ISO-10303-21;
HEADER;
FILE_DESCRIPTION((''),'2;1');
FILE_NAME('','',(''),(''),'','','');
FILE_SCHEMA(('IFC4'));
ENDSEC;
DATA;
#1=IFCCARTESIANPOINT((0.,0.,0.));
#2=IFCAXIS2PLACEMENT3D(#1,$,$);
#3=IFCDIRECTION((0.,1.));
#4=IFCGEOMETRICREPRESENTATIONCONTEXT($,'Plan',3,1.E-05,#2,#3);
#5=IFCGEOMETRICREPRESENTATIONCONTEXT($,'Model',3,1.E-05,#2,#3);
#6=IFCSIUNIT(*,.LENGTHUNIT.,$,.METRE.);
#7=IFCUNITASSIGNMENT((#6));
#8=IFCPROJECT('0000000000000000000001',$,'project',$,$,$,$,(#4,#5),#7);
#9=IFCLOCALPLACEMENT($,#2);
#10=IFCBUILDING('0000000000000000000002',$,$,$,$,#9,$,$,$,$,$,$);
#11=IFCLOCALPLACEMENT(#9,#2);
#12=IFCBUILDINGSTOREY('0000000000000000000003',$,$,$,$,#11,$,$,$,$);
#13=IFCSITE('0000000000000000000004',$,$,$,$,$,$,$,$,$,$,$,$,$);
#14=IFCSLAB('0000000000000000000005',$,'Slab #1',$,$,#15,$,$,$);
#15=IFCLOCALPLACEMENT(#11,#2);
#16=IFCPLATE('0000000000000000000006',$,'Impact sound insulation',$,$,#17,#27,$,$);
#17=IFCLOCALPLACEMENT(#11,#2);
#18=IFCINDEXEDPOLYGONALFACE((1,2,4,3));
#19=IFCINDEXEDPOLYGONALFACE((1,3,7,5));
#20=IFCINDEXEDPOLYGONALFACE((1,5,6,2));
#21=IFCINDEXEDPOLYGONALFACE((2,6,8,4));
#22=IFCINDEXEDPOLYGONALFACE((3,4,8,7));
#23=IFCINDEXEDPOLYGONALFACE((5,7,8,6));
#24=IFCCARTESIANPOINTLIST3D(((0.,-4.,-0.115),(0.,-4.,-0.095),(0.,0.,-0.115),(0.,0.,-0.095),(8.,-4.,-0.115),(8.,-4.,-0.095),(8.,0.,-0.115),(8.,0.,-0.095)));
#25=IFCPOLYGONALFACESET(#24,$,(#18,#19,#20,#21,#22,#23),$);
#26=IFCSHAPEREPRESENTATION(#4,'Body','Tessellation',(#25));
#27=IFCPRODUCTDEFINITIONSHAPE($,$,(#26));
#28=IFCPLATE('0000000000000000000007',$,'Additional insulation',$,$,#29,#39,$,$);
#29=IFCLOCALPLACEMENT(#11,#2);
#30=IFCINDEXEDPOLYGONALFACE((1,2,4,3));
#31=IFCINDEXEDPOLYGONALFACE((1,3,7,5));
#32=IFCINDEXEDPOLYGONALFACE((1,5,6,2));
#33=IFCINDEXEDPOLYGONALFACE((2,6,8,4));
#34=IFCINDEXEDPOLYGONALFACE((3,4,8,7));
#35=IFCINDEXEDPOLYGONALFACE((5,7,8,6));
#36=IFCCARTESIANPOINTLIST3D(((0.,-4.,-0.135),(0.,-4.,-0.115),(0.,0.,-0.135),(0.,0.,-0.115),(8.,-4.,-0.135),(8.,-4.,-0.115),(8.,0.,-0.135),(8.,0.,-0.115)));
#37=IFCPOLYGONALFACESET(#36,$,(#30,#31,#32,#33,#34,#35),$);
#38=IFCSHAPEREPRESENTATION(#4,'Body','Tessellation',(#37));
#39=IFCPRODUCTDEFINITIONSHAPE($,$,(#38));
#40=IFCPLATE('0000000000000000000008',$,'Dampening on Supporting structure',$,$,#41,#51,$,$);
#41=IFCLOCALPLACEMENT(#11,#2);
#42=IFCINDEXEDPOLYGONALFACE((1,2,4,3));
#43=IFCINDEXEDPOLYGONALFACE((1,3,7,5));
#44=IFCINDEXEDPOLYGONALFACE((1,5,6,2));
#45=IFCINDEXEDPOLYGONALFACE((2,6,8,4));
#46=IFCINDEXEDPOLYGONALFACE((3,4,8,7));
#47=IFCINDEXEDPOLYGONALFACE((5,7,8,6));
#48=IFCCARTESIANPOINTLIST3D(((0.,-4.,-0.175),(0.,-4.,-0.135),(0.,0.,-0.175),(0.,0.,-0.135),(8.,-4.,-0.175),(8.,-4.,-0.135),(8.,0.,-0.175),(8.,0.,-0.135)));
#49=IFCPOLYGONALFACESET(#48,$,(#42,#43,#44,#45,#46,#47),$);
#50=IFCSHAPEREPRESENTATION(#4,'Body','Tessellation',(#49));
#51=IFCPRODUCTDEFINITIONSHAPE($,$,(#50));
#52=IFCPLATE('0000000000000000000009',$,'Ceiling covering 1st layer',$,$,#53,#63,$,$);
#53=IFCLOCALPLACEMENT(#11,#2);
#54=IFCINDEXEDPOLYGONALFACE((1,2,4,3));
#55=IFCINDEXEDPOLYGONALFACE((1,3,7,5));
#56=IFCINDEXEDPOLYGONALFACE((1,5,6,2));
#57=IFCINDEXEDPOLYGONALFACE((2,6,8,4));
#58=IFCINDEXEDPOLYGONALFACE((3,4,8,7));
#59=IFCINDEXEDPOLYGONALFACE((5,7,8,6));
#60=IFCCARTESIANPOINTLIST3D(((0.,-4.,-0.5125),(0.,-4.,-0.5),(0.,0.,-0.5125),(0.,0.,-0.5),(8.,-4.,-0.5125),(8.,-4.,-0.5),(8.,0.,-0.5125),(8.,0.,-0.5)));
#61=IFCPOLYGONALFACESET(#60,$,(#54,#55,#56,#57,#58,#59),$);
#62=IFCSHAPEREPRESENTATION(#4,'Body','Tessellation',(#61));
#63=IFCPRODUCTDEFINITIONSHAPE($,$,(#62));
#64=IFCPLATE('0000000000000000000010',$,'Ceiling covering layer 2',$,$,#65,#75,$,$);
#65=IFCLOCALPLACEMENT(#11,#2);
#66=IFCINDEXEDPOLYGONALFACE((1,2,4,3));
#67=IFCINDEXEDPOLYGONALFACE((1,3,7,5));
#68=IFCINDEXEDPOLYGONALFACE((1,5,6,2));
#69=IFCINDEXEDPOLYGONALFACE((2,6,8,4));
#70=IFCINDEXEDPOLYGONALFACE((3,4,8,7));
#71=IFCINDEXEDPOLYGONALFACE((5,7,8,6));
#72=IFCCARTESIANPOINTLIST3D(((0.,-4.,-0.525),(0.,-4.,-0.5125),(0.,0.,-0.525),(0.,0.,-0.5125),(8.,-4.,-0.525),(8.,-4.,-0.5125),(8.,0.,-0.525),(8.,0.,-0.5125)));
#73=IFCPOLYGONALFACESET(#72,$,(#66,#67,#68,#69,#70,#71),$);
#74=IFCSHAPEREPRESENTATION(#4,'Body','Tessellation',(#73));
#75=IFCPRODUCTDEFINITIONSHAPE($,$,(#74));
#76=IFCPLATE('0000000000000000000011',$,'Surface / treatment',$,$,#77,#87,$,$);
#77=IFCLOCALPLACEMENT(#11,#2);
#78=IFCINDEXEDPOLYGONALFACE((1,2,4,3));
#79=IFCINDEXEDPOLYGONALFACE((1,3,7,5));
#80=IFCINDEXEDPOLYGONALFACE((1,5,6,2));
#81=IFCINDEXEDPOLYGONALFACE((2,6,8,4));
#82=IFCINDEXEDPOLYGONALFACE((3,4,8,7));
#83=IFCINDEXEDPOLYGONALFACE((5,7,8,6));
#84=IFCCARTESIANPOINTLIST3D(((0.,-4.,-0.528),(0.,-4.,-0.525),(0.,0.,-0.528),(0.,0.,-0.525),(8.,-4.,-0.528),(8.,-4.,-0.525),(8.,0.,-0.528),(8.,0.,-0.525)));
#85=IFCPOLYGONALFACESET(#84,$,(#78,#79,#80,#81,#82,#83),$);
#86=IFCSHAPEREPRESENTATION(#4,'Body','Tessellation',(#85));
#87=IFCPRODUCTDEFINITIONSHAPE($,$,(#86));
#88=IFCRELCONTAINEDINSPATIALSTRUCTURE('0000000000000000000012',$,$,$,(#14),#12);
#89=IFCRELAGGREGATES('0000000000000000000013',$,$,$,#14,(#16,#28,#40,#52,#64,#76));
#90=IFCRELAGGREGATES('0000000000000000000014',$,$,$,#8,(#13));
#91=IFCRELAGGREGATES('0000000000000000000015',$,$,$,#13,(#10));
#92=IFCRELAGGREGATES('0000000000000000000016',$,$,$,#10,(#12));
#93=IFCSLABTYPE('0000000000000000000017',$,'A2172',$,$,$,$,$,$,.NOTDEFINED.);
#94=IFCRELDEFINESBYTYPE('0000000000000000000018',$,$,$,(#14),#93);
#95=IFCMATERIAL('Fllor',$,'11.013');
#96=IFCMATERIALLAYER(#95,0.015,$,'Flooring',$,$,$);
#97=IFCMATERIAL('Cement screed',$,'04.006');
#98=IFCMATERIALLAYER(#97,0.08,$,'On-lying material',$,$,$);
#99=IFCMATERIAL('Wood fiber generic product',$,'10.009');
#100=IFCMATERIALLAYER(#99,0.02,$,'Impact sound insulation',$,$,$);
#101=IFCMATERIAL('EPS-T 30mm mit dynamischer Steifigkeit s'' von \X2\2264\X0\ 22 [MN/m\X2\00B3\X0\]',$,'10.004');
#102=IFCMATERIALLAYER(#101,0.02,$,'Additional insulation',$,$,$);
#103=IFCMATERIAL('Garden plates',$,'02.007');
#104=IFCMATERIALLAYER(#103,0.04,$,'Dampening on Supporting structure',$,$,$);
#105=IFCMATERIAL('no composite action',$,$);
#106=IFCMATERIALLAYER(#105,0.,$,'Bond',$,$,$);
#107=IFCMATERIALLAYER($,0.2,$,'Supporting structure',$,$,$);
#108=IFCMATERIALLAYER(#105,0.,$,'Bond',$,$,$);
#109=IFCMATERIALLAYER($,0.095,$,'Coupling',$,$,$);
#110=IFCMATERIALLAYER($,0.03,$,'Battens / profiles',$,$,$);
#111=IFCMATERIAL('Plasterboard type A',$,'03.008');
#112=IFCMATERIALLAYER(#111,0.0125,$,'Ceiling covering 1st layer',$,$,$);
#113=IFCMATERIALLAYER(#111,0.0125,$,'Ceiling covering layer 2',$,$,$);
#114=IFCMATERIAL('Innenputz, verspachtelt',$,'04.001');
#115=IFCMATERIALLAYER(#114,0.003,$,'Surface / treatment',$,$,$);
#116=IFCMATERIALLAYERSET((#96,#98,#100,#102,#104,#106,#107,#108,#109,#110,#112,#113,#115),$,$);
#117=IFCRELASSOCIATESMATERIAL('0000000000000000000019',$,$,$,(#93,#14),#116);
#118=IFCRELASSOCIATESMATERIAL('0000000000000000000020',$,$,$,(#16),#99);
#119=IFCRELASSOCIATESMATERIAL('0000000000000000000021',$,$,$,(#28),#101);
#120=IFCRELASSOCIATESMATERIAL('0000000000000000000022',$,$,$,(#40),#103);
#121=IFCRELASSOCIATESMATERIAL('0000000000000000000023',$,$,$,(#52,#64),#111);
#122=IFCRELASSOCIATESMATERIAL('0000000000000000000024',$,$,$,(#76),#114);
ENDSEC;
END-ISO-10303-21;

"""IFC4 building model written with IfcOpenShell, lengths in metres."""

from ifc_helpers import new_model, si_unit, direction, frame, frame_2d, origin, place, context, project, spatial, rectangle, extrude, material, layer, layer_set, type_object, element, aggregate, save


model = new_model("IFC4")

# Units and contexts
plan_context = context("Plan", 3, precision=1e-05, world=origin(), true_north=direction((0.0, 1.0)))
model_context = context("Model", 3, precision=1e-05, world=origin(), true_north=direction((0.0, 1.0)))
ifc_project = project(units=[si_unit("LENGTHUNIT", "METRE")], contexts=[plan_context, model_context])

# Site, building, storey
site = spatial("IfcSite", under=ifc_project)
building_placement = place(None, origin())
building = spatial("IfcBuilding", under=site, at=building_placement)
storey_placement = place(building_placement, origin())
storey = spatial("IfcBuildingStorey", under=building, at=storey_placement)

# Slab, plates
ifc_material_1 = material(Name="Fllor", Category="11.013")
ifc_layer_1 = layer(ifc_material_1, 0.015, Name="Flooring")
ifc_material_2 = material(Name="Cement screed", Category="04.006")
ifc_layer_2 = layer(ifc_material_2, 0.08, Name="On-lying material")
ifc_material_3 = material(Name="Wood fiber generic product", Category="10.009")
ifc_layer_3 = layer(ifc_material_3, 0.02, Name="Impact sound insulation")
ifc_material_4 = material(Name="EPS-T 30mm mit dynamischer Steifigkeit s' von ≤ 22 [MN/m³]", Category="10.004")
ifc_layer_4 = layer(ifc_material_4, 0.02, Name="Additional insulation")
ifc_material_5 = material(Name="Garden plates", Category="02.007")
ifc_layer_5 = layer(ifc_material_5, 0.04, Name="Dampening on Supporting structure")
ifc_material_6 = material(Name="no composite action")
ifc_layer_6 = layer(ifc_material_6, 0.0, Name="Bond")
ifc_layer_7 = layer(None, 0.2, Name="Supporting structure")
ifc_layer_8 = layer(ifc_material_6, 0.0, Name="Bond")
ifc_layer_9 = layer(None, 0.095, Name="Coupling")
ifc_layer_10 = layer(None, 0.03, Name="Battens / profiles")
ifc_material_7 = material(Name="Plasterboard type A", Category="03.008")
ifc_layer_11 = layer(ifc_material_7, 0.0125, Name="Ceiling covering 1st layer")
ifc_layer_12 = layer(ifc_material_7, 0.0125, Name="Ceiling covering layer 2")
ifc_material_8 = material(Name="Innenputz, verspachtelt", Category="04.001")
ifc_layer_13 = layer(ifc_material_8, 0.003, Name="Surface / treatment")
ifc_layer_set = layer_set([ifc_layer_1, ifc_layer_2, ifc_layer_3, ifc_layer_4, ifc_layer_5, ifc_layer_6, ifc_layer_7, ifc_layer_8, ifc_layer_9, ifc_layer_10, ifc_layer_11, ifc_layer_12, ifc_layer_13])
slab_type = type_object("IfcSlabType", Name="A2172", PredefinedType="NOTDEFINED", material=ifc_layer_set)
slab_placement = place(None, frame((0.0, 0.0, 0.0), z_axis=(0.0, 0.0, -1.0), x_axis=(1.0, 0.0, 0.0)))
slab = element("IfcSlab", 1, at=slab_placement, inside=storey, type_object=slab_type, material=ifc_layer_set, Name="Slab #1")
plate_1_placement = place(slab_placement, origin())
plate_1 = element("IfcPlate", 2, at=plate_1_placement, material=ifc_material_3, Name="Impact sound insulation", context=plan_context, shape_type="SweptSolid", body=[
    extrude(rectangle(XDim=8.0, YDim=4.0, at=frame_2d((4.0, 2.0), x_axis=(1.0, 0.0))), frame((0.0, 0.0, 0.095), z_axis=(0.0, 0.0, 1.0), x_axis=(1.0, 0.0, 0.0)), (0.0, 0.0, 1.0), 0.02),
])
plate_2_placement = place(slab_placement, origin())
plate_2 = element("IfcPlate", 3, at=plate_2_placement, material=ifc_material_4, Name="Additional insulation", context=plan_context, shape_type="SweptSolid", body=[
    extrude(rectangle(XDim=8.0, YDim=4.0, at=frame_2d((4.0, 2.0), x_axis=(1.0, 0.0))), frame((0.0, 0.0, 0.115), z_axis=(0.0, 0.0, 1.0), x_axis=(1.0, 0.0, 0.0)), (0.0, 0.0, 1.0), 0.02),
])
plate_3_placement = place(slab_placement, origin())
plate_3 = element("IfcPlate", 4, at=plate_3_placement, material=ifc_material_5, Name="Dampening on Supporting structure", context=plan_context, shape_type="SweptSolid", body=[
    extrude(rectangle(XDim=8.0, YDim=4.0, at=frame_2d((4.0, 2.0), x_axis=(1.0, 0.0))), frame((0.0, 0.0, 0.135), z_axis=(0.0, 0.0, 1.0), x_axis=(1.0, 0.0, 0.0)), (0.0, 0.0, 1.0), 0.04),
])
plate_4_placement = place(slab_placement, origin())
plate_4 = element("IfcPlate", 5, at=plate_4_placement, material=ifc_material_7, Name="Ceiling covering 1st layer", context=plan_context, shape_type="SweptSolid", body=[
    extrude(rectangle(XDim=8.0, YDim=4.0, at=frame_2d((4.0, 2.0), x_axis=(1.0, 0.0))), frame((0.0, 0.0, 0.5), z_axis=(0.0, 0.0, 1.0), x_axis=(1.0, 0.0, 0.0)), (0.0, 0.0, 1.0), 0.0125),
])
plate_5_placement = place(slab_placement, origin())
plate_5 = element("IfcPlate", 6, at=plate_5_placement, material=ifc_material_7, Name="Ceiling covering layer 2", context=plan_context, shape_type="SweptSolid", body=[
    extrude(rectangle(XDim=8.0, YDim=4.0, at=frame_2d((4.0, 2.0), x_axis=(1.0, 0.0))), frame((0.0, 0.0, 0.5125), z_axis=(0.0, 0.0, 1.0), x_axis=(1.0, 0.0, 0.0)), (0.0, 0.0, 1.0), 0.0125),
])
plate_6_placement = place(slab_placement, origin())
plate_6 = element("IfcPlate", 7, at=plate_6_placement, material=ifc_material_8, Name="Surface / treatment", context=plan_context, shape_type="SweptSolid", body=[
    extrude(rectangle(XDim=8.0, YDim=4.0, at=frame_2d((4.0, 2.0), x_axis=(1.0, 0.0))), frame((0.0, 0.0, 0.525), z_axis=(0.0, 0.0, 1.0), x_axis=(1.0, 0.0, 0.0)), (0.0, 0.0, 1.0), 0.003),
])
aggregate(slab, [plate_1, plate_2, plate_3, plate_4, plate_5, plate_6])

save(model, "model.ifc")
